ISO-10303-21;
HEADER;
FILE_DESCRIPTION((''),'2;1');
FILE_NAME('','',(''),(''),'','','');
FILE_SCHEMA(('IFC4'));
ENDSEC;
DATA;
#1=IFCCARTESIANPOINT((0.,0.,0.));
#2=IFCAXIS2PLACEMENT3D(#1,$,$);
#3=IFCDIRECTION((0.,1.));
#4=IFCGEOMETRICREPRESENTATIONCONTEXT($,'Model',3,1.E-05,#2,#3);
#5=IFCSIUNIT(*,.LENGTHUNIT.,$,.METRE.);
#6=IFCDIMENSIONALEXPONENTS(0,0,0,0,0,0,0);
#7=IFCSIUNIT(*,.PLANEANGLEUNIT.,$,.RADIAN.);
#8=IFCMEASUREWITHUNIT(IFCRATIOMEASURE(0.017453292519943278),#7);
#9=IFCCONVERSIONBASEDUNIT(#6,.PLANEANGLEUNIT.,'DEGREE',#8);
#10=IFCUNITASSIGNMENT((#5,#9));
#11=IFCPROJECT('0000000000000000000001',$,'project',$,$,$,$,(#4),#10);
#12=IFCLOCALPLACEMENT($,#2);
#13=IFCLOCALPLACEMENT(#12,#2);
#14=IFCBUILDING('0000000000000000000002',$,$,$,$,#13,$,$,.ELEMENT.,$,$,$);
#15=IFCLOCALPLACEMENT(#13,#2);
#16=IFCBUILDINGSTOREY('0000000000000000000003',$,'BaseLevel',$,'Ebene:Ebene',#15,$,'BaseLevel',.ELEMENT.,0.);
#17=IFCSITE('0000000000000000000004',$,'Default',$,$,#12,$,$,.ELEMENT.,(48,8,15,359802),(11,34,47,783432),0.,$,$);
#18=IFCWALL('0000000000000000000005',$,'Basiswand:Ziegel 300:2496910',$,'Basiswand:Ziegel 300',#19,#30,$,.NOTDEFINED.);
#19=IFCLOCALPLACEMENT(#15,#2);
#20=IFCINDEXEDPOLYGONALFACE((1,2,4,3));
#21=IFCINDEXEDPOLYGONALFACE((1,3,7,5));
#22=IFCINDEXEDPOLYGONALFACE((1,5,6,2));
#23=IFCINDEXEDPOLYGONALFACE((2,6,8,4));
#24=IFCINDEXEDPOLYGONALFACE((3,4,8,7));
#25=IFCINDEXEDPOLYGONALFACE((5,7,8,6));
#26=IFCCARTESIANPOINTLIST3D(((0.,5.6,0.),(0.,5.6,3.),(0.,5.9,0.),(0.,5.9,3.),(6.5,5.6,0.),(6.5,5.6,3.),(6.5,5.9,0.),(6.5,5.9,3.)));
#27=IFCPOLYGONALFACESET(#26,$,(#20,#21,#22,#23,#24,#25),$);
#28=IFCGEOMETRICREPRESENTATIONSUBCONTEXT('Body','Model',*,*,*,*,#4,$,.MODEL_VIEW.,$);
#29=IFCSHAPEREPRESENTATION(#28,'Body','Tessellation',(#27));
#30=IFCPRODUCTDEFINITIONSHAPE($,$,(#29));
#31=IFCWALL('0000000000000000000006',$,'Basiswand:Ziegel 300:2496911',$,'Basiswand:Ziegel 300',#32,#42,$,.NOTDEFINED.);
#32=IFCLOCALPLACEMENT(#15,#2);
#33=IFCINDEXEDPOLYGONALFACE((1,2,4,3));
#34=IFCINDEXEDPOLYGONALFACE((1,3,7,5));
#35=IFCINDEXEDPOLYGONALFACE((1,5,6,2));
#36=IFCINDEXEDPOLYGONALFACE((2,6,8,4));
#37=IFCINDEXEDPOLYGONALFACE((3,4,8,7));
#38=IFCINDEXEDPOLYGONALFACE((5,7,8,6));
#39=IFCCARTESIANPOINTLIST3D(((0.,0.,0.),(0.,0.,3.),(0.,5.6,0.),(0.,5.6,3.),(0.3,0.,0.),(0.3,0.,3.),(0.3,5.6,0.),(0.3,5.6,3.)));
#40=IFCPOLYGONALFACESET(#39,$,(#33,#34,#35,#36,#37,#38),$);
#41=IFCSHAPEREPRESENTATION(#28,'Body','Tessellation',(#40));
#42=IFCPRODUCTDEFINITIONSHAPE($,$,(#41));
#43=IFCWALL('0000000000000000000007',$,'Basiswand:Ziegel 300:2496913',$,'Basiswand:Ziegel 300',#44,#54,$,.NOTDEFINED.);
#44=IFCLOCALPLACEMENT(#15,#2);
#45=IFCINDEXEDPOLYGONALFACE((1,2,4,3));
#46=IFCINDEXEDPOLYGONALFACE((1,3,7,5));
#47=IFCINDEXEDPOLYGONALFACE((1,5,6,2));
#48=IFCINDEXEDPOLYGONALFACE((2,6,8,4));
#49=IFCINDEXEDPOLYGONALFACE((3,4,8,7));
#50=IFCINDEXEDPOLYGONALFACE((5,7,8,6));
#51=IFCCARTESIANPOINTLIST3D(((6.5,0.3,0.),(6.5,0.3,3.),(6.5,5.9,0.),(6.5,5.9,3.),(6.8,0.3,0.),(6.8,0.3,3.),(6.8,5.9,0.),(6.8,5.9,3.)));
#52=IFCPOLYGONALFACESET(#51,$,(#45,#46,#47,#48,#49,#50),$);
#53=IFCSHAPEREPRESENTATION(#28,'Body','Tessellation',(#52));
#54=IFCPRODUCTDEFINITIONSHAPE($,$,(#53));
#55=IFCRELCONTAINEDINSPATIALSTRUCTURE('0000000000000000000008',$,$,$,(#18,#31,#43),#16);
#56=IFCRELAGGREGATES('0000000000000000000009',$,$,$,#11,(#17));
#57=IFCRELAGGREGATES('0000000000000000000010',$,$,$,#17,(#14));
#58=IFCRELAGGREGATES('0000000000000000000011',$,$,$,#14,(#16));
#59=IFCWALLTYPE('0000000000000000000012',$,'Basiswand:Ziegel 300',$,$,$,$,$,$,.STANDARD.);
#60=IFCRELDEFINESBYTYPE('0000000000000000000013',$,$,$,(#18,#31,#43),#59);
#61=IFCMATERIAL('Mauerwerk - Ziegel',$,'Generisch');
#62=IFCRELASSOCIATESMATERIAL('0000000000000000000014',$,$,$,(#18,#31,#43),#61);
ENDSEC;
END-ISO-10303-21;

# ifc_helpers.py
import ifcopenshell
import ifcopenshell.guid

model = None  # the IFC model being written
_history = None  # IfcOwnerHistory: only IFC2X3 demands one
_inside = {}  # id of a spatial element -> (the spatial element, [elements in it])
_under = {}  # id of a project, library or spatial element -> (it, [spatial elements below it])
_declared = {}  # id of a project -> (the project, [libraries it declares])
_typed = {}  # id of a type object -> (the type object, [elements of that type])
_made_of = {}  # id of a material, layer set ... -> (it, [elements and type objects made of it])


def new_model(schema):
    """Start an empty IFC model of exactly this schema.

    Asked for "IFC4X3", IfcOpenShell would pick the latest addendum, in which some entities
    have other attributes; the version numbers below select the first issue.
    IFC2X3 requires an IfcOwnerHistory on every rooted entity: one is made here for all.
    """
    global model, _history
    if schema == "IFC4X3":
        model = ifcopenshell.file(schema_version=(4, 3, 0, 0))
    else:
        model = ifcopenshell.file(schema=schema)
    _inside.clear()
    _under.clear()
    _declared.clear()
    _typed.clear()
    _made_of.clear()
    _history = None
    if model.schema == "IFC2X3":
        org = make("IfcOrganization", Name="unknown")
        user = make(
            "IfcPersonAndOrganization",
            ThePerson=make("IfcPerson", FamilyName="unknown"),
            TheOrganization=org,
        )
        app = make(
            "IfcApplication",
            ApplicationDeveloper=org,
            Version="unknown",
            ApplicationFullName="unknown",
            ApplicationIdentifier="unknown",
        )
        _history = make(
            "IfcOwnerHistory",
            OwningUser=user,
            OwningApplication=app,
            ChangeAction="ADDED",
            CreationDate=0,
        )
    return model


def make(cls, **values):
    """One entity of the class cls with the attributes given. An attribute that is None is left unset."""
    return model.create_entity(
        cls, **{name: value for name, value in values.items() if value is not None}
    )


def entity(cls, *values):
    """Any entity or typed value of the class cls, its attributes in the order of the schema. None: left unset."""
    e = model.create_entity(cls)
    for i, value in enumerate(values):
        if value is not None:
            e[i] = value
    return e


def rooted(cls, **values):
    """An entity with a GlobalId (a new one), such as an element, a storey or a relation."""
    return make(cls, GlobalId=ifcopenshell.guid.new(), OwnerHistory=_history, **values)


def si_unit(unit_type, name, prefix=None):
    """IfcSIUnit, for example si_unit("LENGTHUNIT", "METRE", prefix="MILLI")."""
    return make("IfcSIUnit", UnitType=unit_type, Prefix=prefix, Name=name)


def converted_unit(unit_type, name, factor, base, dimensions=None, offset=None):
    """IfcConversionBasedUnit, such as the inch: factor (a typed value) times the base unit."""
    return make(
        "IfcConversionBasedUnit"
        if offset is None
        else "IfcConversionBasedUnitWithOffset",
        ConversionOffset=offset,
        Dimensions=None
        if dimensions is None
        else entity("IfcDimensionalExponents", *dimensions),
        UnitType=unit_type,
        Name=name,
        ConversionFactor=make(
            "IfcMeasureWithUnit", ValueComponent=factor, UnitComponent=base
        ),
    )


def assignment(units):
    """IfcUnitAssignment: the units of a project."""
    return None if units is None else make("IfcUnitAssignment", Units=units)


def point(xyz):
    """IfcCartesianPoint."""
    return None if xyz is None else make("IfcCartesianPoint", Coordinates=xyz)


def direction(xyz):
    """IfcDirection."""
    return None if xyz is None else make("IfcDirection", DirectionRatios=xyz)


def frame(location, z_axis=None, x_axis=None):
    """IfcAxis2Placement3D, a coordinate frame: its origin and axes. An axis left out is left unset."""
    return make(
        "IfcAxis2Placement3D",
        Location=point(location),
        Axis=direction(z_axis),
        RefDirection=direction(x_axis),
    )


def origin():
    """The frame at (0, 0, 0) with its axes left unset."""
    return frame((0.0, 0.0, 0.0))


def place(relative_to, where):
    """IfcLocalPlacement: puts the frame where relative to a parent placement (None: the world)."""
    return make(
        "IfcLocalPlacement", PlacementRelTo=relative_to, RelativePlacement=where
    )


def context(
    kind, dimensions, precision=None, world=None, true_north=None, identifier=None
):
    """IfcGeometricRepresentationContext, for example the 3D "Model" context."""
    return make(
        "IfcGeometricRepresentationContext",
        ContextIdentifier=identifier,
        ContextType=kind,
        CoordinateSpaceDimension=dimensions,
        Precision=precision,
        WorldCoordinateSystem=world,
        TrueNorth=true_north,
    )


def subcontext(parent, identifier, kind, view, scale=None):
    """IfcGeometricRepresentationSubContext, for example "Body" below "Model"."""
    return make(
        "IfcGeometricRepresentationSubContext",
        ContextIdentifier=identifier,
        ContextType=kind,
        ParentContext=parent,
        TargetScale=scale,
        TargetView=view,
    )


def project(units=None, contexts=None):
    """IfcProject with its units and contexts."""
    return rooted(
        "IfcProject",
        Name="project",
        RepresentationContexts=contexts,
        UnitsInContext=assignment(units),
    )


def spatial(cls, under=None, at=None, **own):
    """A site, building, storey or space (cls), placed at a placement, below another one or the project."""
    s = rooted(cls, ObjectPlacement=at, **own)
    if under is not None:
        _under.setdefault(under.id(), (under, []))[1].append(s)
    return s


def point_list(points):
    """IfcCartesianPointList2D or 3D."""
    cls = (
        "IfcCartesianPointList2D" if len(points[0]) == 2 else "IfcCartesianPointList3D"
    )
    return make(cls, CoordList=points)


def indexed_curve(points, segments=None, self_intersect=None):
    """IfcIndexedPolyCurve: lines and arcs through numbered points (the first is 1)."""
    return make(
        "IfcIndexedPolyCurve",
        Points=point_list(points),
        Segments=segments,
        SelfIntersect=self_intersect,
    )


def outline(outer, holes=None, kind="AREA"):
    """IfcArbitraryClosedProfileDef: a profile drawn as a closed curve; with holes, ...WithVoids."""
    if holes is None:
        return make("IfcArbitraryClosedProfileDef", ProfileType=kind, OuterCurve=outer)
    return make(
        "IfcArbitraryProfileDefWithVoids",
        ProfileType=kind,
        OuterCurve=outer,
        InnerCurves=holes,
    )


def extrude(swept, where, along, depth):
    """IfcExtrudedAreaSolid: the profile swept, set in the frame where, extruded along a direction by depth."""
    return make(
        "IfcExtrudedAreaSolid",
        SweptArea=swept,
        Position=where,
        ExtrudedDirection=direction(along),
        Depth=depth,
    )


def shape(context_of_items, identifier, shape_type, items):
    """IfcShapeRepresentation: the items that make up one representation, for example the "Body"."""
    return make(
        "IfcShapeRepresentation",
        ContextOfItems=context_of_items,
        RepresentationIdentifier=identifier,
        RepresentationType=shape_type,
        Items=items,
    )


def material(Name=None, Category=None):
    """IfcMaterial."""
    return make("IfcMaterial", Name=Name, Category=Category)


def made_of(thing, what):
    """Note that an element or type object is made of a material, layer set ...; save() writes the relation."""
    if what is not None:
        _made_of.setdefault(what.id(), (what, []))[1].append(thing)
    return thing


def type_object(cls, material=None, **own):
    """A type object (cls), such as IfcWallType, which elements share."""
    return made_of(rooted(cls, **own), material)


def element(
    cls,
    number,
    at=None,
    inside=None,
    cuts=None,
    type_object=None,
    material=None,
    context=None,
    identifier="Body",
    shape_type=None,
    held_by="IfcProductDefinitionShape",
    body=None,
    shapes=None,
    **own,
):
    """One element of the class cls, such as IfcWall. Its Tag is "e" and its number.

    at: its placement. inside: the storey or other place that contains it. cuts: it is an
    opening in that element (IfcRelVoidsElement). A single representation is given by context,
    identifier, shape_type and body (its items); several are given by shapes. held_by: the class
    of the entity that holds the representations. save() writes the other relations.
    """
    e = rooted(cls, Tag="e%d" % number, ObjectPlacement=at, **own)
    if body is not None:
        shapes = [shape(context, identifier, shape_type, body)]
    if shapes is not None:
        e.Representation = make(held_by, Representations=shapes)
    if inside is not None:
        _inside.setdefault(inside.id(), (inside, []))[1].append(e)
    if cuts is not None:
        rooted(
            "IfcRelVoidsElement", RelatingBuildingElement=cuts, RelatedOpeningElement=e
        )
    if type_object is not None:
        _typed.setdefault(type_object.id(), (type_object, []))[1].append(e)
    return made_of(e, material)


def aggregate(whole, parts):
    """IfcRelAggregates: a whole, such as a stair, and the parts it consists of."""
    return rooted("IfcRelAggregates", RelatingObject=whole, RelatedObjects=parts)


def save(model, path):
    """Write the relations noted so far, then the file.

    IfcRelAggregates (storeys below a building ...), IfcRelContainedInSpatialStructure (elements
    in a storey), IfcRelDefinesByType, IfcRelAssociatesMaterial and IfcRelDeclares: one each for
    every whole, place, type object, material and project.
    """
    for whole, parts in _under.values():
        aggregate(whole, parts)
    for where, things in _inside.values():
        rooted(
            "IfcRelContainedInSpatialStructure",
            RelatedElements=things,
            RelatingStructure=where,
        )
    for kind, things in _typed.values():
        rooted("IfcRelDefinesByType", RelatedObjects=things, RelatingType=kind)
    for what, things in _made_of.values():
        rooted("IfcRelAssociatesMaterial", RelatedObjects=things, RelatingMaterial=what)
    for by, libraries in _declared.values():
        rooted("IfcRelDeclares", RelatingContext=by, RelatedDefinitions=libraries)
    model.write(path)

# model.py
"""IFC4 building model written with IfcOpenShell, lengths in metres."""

from ifc_helpers import new_model, entity, si_unit, converted_unit, direction, frame, origin, place, context, subcontext, project, spatial, indexed_curve, outline, extrude, material, type_object, element, save


model = new_model("IFC4")

# Units and contexts
model_context = context("Model", 3, precision=1e-05, world=origin(), true_north=direction((0.0, 1.0)))
body_context = subcontext(model_context, "Body", "Model", "MODEL_VIEW")
ifc_project = project(units=[si_unit("LENGTHUNIT", "METRE"), converted_unit("PLANEANGLEUNIT", "DEGREE", entity("IfcRatioMeasure", 0.017453292519943278), si_unit("PLANEANGLEUNIT", "RADIAN"), dimensions=[0, 0, 0, 0, 0, 0, 0])], contexts=[model_context])

# Site, building, storey
site_placement = place(None, origin())
site = spatial("IfcSite", under=ifc_project, at=site_placement, Name="Default", CompositionType="ELEMENT", RefLatitude=(48, 8, 15, 359802), RefLongitude=(11, 34, 47, 783432), RefElevation=0.0)
building_placement = place(site_placement, origin())
building = spatial("IfcBuilding", under=site, at=building_placement, CompositionType="ELEMENT")
storey_placement = place(building_placement, origin())
storey = spatial("IfcBuildingStorey", under=building, at=storey_placement, Name="BaseLevel", ObjectType="Ebene:Ebene", LongName="BaseLevel", CompositionType="ELEMENT", Elevation=0.0)

# Walls
ifc_material = material(Name="Mauerwerk - Ziegel", Category="Generisch")
wall_type = type_object("IfcWallType", Name="Basiswand:Ziegel 300", PredefinedType="STANDARD")
wall_1_placement = place(storey_placement, frame((0.0, 5.75, 0.0)))
element("IfcWall", 1, at=wall_1_placement, inside=storey, type_object=wall_type, material=ifc_material, Name="Basiswand:Ziegel 300:2496910", ObjectType="Basiswand:Ziegel 300", PredefinedType="NOTDEFINED", context=body_context, shape_type="SweptSolid", body=[
    extrude(outline(indexed_curve([(6.5, 0.15), (0.0, 0.15), (0.0, -0.15), (6.5, -0.15), (6.5, 0.15)], self_intersect=False)), origin(), (0.0, 0.0, 1.0), 3.0),
])
wall_2_placement = place(storey_placement, frame((0.15, 0.0, 0.0), z_axis=(0.0, 0.0, 1.0), x_axis=(0.0, 1.0, 0.0)))
element("IfcWall", 2, at=wall_2_placement, inside=storey, type_object=wall_type, material=ifc_material, Name="Basiswand:Ziegel 300:2496911", ObjectType="Basiswand:Ziegel 300", PredefinedType="NOTDEFINED", context=body_context, shape_type="SweptSolid", body=[
    extrude(outline(indexed_curve([(5.6, 0.15), (0.0, 0.15), (0.0, -0.15), (5.6, -0.15), (5.6, 0.15)], self_intersect=False)), origin(), (0.0, 0.0, 1.0), 3.0),
])
wall_3_placement = place(storey_placement, frame((6.65, 5.9, 0.0), z_axis=(0.0, 0.0, 1.0), x_axis=(0.0, -1.0, 0.0)))
element("IfcWall", 3, at=wall_3_placement, inside=storey, type_object=wall_type, material=ifc_material, Name="Basiswand:Ziegel 300:2496913", ObjectType="Basiswand:Ziegel 300", PredefinedType="NOTDEFINED", context=body_context, shape_type="SweptSolid", body=[
    extrude(outline(indexed_curve([(5.6, 0.15), (0.0, 0.15), (0.0, -0.15), (5.6, -0.15), (5.6, 0.15)], self_intersect=False)), origin(), (0.0, 0.0, 1.0), 3.0),
])

save(model, "model.ifc")
